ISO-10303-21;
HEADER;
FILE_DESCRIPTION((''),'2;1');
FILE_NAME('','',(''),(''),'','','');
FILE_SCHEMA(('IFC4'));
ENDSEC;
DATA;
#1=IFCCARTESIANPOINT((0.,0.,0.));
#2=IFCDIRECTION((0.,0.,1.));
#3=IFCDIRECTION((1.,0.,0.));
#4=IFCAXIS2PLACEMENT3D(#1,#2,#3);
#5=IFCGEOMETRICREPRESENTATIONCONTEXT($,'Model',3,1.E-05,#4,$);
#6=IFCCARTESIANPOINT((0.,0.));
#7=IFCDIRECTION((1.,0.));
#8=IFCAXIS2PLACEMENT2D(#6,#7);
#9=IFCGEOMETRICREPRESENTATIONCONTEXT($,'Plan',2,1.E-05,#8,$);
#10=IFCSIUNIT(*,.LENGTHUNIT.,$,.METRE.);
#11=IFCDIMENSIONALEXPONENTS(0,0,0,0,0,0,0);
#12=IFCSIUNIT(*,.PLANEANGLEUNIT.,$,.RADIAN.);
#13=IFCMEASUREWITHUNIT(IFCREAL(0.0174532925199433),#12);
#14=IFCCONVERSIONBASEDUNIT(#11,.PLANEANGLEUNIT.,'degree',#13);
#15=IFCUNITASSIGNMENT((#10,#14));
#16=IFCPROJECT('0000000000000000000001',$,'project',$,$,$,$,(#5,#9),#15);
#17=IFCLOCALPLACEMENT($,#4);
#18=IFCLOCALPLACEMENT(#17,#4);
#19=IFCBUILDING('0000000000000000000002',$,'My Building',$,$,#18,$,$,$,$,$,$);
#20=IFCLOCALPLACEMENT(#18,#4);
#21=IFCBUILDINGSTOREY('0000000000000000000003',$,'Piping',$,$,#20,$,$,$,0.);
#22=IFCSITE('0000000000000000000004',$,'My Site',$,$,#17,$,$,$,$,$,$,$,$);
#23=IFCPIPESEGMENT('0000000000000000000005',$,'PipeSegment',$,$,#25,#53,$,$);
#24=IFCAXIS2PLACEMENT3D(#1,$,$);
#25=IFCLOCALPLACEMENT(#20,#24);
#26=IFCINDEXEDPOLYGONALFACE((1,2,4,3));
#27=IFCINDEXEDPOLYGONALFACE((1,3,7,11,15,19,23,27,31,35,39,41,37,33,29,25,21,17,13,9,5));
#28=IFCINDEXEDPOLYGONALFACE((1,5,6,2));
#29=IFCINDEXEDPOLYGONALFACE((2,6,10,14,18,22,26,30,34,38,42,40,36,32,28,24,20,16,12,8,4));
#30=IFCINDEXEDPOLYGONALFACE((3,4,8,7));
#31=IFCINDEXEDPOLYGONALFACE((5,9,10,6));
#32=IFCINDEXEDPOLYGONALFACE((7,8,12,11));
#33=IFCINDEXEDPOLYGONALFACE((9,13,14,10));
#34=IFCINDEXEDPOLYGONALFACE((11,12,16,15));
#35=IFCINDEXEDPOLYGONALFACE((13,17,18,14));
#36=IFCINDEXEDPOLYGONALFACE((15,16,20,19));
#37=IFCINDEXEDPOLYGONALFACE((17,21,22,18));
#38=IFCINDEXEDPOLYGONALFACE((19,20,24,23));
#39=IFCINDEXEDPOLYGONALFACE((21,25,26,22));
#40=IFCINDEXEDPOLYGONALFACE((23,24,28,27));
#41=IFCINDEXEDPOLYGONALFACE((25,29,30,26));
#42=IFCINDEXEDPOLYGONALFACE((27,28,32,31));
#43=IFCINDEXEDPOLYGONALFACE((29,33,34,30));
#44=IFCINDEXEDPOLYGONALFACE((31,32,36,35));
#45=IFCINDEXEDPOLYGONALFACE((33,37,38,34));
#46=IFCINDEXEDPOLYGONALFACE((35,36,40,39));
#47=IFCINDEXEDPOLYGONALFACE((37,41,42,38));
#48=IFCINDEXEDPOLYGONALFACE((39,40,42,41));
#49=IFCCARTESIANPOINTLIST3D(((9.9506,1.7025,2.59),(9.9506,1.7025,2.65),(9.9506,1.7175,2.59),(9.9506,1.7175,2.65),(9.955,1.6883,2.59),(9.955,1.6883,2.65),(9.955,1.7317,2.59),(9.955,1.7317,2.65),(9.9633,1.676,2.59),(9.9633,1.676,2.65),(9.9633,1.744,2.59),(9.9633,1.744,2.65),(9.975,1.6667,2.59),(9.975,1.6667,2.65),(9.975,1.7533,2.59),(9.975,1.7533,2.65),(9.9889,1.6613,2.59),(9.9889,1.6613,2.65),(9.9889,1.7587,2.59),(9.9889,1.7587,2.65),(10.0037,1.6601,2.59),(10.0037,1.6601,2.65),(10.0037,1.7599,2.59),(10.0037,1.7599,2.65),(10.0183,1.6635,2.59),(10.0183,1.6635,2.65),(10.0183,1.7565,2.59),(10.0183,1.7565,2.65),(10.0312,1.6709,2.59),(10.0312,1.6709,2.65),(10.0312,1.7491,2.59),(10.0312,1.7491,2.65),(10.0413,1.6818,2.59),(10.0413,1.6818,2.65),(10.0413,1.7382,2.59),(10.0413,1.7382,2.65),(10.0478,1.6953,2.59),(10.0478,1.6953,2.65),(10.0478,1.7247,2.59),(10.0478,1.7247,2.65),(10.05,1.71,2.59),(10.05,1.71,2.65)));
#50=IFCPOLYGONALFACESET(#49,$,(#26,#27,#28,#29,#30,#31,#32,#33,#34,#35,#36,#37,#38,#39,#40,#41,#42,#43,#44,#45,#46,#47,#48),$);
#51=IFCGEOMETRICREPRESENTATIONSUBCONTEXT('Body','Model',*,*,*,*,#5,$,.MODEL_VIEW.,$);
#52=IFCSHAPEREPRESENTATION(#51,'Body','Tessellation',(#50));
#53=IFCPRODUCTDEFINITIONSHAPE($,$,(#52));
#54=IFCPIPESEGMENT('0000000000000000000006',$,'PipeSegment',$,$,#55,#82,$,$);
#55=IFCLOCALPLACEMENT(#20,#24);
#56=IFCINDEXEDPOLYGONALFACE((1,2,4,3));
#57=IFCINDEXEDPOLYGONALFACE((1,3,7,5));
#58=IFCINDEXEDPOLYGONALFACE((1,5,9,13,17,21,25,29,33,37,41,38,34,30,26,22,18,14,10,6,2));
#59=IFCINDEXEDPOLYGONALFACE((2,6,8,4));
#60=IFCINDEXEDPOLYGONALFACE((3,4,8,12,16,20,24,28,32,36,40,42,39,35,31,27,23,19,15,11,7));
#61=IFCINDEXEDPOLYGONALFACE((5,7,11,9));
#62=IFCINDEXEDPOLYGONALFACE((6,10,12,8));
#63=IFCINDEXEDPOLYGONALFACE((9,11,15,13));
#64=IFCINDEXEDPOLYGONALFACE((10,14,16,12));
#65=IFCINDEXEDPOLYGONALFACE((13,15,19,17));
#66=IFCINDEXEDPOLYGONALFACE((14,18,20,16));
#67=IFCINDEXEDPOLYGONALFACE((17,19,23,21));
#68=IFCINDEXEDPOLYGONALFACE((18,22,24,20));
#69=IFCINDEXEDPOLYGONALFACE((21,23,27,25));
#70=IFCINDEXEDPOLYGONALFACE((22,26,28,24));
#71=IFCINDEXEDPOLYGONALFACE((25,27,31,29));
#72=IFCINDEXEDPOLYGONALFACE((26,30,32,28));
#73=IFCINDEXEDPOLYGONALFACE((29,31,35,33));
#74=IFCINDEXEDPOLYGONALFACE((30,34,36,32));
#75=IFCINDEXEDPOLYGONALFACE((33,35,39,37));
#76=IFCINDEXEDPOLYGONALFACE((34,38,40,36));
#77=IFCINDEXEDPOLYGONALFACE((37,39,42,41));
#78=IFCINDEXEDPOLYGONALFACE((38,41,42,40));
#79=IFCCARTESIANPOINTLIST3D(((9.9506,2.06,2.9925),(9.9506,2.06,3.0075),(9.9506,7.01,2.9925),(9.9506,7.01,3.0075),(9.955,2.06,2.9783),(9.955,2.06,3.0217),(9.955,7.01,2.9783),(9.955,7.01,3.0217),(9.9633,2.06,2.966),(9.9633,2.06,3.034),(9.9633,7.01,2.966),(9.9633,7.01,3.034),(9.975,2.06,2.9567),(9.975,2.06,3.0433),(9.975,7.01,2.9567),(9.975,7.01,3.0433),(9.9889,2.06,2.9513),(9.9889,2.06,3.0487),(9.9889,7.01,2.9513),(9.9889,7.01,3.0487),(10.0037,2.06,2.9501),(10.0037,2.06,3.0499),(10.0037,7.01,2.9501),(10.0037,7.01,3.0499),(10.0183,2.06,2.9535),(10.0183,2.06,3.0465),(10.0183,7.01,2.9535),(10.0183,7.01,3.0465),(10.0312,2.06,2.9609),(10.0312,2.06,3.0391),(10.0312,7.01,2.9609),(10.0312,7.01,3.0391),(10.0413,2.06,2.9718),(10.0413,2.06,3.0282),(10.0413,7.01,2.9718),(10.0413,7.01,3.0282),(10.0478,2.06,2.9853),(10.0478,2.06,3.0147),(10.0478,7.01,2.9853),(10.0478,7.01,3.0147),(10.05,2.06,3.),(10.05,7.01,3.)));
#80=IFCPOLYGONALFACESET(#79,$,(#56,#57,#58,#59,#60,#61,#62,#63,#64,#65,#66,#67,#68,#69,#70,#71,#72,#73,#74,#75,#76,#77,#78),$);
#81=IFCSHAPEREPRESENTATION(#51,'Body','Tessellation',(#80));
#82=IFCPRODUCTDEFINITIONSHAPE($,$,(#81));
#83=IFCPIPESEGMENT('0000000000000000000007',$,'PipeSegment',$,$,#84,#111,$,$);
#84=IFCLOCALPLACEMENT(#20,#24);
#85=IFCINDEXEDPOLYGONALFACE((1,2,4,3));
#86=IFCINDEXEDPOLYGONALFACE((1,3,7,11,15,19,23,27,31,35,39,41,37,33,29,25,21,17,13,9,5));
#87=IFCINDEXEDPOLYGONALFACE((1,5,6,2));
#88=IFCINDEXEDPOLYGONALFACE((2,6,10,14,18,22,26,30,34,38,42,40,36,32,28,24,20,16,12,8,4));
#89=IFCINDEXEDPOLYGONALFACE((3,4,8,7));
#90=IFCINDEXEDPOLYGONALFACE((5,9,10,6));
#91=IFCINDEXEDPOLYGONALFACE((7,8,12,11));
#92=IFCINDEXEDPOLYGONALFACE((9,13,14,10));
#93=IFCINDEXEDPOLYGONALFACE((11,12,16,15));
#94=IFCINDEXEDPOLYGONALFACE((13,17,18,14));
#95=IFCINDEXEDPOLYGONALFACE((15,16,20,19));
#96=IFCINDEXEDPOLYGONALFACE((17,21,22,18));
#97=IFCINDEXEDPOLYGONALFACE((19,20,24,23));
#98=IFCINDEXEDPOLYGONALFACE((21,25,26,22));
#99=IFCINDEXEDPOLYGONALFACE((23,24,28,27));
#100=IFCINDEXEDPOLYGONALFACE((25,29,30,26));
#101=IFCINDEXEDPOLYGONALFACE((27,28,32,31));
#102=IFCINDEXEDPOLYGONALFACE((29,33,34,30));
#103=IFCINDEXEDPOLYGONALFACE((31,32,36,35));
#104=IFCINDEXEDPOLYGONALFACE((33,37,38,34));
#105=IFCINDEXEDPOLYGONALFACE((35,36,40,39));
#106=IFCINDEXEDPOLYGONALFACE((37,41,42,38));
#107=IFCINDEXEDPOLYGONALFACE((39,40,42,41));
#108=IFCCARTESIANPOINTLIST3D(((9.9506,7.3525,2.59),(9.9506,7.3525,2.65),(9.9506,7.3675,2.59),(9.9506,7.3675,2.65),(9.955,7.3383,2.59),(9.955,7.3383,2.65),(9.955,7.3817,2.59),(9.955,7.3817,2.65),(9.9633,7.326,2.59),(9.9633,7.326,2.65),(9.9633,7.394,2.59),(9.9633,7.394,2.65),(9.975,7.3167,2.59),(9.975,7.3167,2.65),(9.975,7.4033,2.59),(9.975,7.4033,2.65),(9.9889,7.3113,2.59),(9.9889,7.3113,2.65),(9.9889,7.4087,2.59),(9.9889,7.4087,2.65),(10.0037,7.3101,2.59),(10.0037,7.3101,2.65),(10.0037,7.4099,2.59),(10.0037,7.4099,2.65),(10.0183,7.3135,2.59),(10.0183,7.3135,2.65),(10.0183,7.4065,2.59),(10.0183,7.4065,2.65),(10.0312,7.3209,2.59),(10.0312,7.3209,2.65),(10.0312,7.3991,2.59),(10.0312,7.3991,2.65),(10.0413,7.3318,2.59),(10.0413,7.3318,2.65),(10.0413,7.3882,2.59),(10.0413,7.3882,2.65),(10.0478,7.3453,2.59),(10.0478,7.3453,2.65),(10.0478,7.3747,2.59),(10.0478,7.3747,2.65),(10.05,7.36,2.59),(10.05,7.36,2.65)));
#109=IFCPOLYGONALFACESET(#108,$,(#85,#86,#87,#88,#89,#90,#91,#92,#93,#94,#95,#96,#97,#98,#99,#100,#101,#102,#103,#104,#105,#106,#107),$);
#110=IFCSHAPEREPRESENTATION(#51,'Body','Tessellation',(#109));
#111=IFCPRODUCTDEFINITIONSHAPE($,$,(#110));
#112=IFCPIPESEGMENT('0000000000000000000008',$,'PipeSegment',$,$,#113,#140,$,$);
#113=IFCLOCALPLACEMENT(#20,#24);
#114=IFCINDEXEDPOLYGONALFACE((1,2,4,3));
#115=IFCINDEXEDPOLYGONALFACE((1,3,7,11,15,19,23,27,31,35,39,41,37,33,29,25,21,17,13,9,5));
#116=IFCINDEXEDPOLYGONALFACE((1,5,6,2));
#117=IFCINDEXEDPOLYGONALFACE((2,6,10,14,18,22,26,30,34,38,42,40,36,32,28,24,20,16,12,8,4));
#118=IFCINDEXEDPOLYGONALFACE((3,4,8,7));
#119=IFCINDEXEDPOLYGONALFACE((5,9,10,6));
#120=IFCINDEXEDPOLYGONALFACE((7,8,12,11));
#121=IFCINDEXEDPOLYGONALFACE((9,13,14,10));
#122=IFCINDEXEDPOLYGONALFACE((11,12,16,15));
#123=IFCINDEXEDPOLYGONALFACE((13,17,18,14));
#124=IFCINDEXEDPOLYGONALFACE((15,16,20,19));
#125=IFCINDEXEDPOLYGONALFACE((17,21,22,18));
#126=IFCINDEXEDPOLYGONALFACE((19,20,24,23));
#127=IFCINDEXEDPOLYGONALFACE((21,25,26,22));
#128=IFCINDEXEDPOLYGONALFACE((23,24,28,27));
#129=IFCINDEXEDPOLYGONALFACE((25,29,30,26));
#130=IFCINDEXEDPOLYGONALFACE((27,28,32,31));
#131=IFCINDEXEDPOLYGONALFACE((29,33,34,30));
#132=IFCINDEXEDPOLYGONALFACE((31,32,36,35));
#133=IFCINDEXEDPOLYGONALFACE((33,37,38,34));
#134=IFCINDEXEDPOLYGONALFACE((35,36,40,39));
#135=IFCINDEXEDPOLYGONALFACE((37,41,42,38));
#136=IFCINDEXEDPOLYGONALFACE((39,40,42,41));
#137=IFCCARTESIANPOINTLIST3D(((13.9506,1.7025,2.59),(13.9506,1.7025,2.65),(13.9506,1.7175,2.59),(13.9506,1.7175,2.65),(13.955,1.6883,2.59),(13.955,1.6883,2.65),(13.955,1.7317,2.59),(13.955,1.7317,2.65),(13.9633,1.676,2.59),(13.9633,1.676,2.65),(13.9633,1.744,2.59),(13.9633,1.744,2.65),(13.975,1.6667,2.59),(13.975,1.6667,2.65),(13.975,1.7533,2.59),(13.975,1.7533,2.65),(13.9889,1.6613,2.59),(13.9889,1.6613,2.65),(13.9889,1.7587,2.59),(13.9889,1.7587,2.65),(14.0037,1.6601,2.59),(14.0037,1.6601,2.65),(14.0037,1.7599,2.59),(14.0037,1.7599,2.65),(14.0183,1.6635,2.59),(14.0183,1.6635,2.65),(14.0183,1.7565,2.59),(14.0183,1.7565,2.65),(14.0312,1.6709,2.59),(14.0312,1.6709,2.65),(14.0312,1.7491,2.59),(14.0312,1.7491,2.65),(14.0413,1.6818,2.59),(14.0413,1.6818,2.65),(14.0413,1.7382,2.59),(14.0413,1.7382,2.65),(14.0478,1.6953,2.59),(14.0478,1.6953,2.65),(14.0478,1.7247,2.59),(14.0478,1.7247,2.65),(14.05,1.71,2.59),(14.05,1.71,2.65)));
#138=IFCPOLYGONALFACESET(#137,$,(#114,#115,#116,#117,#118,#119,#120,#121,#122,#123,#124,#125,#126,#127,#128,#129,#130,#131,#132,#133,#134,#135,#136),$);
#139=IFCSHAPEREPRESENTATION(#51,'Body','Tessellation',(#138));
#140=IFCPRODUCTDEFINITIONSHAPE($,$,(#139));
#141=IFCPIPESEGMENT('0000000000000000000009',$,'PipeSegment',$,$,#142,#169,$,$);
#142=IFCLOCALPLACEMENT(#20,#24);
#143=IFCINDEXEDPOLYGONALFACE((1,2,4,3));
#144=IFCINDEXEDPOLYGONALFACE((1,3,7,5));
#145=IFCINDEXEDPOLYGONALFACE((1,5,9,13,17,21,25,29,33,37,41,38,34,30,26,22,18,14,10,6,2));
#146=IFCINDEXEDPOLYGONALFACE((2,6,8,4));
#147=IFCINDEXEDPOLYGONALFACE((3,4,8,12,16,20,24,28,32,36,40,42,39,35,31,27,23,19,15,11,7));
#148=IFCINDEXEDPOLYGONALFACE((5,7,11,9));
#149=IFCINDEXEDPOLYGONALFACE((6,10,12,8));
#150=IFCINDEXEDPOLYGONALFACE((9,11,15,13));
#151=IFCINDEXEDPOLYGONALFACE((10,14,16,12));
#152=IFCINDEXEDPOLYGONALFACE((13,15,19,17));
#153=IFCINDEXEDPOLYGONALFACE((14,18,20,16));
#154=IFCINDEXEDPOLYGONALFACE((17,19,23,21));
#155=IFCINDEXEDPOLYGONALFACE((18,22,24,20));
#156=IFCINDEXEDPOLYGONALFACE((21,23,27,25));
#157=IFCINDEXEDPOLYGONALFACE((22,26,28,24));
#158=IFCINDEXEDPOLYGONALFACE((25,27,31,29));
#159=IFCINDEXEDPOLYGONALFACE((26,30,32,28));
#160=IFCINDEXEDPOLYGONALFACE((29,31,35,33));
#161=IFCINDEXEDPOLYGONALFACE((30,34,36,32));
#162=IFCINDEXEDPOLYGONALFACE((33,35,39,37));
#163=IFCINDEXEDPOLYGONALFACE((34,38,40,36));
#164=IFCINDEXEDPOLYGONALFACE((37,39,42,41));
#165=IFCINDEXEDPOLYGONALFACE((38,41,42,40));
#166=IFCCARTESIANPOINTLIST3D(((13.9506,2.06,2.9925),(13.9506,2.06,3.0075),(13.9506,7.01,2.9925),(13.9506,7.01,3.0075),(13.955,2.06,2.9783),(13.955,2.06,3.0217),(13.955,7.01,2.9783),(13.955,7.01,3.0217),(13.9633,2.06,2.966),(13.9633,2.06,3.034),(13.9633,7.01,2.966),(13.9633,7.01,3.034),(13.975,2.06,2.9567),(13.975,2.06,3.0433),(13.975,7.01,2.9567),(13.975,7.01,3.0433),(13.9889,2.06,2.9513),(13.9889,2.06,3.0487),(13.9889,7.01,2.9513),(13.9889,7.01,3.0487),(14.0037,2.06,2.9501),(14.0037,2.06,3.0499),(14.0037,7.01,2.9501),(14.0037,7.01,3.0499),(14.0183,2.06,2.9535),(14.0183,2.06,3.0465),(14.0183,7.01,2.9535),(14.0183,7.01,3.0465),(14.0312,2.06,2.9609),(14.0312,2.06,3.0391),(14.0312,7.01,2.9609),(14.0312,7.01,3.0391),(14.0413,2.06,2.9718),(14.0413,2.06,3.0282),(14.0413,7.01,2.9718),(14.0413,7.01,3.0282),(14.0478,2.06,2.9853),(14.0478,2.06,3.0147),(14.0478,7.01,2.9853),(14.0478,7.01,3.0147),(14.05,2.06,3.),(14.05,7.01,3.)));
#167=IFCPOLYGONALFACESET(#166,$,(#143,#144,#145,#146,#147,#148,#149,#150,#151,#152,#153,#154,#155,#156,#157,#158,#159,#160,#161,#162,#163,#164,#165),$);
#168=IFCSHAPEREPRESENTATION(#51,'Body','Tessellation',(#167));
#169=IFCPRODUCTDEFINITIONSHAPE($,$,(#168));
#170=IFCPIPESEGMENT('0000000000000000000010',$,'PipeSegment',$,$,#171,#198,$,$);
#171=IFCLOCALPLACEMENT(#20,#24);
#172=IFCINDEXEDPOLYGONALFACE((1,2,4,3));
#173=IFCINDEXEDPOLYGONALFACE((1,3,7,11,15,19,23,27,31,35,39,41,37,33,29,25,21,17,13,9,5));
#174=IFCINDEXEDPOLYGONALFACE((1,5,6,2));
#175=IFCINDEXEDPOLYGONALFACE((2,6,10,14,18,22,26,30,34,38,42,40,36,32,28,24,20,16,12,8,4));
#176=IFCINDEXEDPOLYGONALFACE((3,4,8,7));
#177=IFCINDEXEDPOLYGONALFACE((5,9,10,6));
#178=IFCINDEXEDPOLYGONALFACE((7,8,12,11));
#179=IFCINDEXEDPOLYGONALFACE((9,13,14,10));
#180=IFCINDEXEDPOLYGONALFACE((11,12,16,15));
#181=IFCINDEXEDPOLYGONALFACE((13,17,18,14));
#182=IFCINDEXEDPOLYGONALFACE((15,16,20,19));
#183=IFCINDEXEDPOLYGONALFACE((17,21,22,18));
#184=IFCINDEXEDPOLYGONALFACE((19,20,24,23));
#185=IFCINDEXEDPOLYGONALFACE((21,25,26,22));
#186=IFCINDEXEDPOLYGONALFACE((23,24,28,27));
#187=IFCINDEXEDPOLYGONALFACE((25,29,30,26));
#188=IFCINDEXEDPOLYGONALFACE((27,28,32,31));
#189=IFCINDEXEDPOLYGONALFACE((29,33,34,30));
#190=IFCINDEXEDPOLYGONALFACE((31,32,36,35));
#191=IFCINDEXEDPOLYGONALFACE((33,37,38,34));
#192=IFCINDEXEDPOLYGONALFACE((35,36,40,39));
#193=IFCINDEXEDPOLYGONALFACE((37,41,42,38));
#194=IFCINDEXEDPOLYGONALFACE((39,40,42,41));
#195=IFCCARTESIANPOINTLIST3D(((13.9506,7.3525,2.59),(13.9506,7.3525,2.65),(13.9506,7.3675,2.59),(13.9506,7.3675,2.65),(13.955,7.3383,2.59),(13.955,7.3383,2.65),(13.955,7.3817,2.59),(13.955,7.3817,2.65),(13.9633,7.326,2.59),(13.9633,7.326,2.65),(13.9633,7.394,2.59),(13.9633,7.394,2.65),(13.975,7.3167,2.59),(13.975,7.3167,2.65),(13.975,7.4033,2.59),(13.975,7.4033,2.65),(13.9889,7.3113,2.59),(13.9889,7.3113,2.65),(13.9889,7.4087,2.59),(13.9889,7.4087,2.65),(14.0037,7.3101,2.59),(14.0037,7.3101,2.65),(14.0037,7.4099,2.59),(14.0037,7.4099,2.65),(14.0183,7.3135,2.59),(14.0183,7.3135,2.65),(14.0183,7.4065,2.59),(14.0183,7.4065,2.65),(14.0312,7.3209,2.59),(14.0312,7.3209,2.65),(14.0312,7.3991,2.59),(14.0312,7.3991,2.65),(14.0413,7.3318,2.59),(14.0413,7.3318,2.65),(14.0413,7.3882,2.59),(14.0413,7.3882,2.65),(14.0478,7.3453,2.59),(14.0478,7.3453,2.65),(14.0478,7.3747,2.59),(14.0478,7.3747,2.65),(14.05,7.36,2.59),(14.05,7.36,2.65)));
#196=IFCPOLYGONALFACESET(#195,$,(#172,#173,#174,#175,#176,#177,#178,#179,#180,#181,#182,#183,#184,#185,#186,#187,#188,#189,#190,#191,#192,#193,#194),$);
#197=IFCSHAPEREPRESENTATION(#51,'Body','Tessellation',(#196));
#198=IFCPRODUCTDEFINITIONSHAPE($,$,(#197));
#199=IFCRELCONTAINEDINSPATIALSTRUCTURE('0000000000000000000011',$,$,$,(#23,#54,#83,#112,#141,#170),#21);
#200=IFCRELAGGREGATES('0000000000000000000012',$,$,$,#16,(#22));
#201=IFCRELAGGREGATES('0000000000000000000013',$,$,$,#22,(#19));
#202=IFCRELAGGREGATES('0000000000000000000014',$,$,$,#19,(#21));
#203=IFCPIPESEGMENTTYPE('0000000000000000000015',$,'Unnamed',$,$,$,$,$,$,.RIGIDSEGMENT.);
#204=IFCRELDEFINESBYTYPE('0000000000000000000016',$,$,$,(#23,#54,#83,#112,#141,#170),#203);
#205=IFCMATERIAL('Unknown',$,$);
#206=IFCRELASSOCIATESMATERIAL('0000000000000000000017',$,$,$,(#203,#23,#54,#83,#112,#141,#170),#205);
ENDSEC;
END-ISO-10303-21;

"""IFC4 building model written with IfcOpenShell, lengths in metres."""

from ifc_helpers import new_model, entity, si_unit, converted_unit, frame, origin_with_axes, origin_2d_with_axis, place, context, subcontext, project, spatial, circle, extrude, material, material_profile, profile_set, profile_usage, type_object, element, save


model = new_model("IFC4")

# Units and contexts
model_context = context("Model", 3, precision=1e-05, world=origin_with_axes())
plan_context = context("Plan", 2, precision=1e-05, world=origin_2d_with_axis())
body_context = subcontext(model_context, "Body", "Model", "MODEL_VIEW")
ifc_project = project(units=[si_unit("LENGTHUNIT", "METRE"), converted_unit("PLANEANGLEUNIT", "degree", entity("IfcReal", 0.0174532925199433), si_unit("PLANEANGLEUNIT", "RADIAN"), dimensions=[0, 0, 0, 0, 0, 0, 0])], contexts=[model_context, plan_context])

# Site, building, storey
site_placement = place(None, origin_with_axes())
site = spatial("IfcSite", under=ifc_project, at=site_placement, Name="My Site")
building_placement = place(site_placement, origin_with_axes())
building = spatial("IfcBuilding", under=site, at=building_placement, Name="My Building")
storey_placement = place(building_placement, origin_with_axes())
storey = spatial("IfcBuildingStorey", under=building, at=storey_placement, Name="Piping", Elevation=0.0)

# Pipe segments
ifc_material = material(Name="Unknown")
ifc_material_profile = material_profile(ifc_material, circle(Radius=0.05))
ifc_profile_set = profile_set([ifc_material_profile])
pipe_segment_type = type_object("IfcPipeSegmentType", Name="Unnamed", PredefinedType="RIGIDSEGMENT", material=ifc_profile_set)
ifc_profile_usage_1 = profile_usage(ifc_profile_set)
pipe_segment_1_placement = place(storey_placement, frame((10.0, 1.71, 2.59), z_axis=(0.0, 0.0, 1.0), x_axis=(1.0, 0.0, 0.0)))
element("IfcPipeSegment", 1, at=pipe_segment_1_placement, inside=storey, type_object=pipe_segment_type, material=ifc_profile_usage_1, Name="PipeSegment", context=body_context, shape_type="SweptSolid", body=[
    extrude(circle(Radius=0.05), origin_with_axes(), (0.0, 0.0, 1.0), 0.06),
])
ifc_profile_usage_2 = profile_usage(ifc_profile_set)
pipe_segment_2_placement = place(storey_placement, frame((10.0, 2.06, 3.0), z_axis=(0.0, 1.0, 0.0), x_axis=(1.0, 0.0, 0.0)))
element("IfcPipeSegment", 2, at=pipe_segment_2_placement, inside=storey, type_object=pipe_segment_type, material=ifc_profile_usage_2, Name="PipeSegment", context=body_context, shape_type="SweptSolid", body=[
    extrude(circle(Radius=0.05), origin_with_axes(), (0.0, 0.0, 1.0), 4.95),
])
ifc_profile_usage_3 = profile_usage(ifc_profile_set)
pipe_segment_3_placement = place(storey_placement, frame((10.0, 7.36, 2.65), z_axis=(0.0, 0.0, -1.0), x_axis=(1.0, 0.0, 0.0)))
element("IfcPipeSegment", 3, at=pipe_segment_3_placement, inside=storey, type_object=pipe_segment_type, material=ifc_profile_usage_3, Name="PipeSegment", context=body_context, shape_type="SweptSolid", body=[
    extrude(circle(Radius=0.05), origin_with_axes(), (0.0, 0.0, 1.0), 0.06),
])
ifc_profile_usage_4 = profile_usage(ifc_profile_set)
pipe_segment_4_placement = place(storey_placement, frame((14.0, 1.71, 2.59), z_axis=(0.0, 0.0, 1.0), x_axis=(1.0, 0.0, 0.0)))
element("IfcPipeSegment", 4, at=pipe_segment_4_placement, inside=storey, type_object=pipe_segment_type, material=ifc_profile_usage_4, Name="PipeSegment", context=body_context, shape_type="SweptSolid", body=[
    extrude(circle(Radius=0.05), origin_with_axes(), (0.0, 0.0, 1.0), 0.06),
])
ifc_profile_usage_5 = profile_usage(ifc_profile_set)
pipe_segment_5_placement = place(storey_placement, frame((14.0, 2.06, 3.0), z_axis=(0.0, 1.0, 0.0), x_axis=(1.0, 0.0, 0.0)))
element("IfcPipeSegment", 5, at=pipe_segment_5_placement, inside=storey, type_object=pipe_segment_type, material=ifc_profile_usage_5, Name="PipeSegment", context=body_context, shape_type="SweptSolid", body=[
    extrude(circle(Radius=0.05), origin_with_axes(), (0.0, 0.0, 1.0), 4.95),
])
ifc_profile_usage_6 = profile_usage(ifc_profile_set)
pipe_segment_6_placement = place(storey_placement, frame((14.0, 7.36, 2.65), z_axis=(0.0, 0.0, -1.0), x_axis=(1.0, 0.0, 0.0)))
element("IfcPipeSegment", 6, at=pipe_segment_6_placement, inside=storey, type_object=pipe_segment_type, material=ifc_profile_usage_6, Name="PipeSegment", context=body_context, shape_type="SweptSolid", body=[
    extrude(circle(Radius=0.05), origin_with_axes(), (0.0, 0.0, 1.0), 0.06),
])

save(model, "model.ifc")
